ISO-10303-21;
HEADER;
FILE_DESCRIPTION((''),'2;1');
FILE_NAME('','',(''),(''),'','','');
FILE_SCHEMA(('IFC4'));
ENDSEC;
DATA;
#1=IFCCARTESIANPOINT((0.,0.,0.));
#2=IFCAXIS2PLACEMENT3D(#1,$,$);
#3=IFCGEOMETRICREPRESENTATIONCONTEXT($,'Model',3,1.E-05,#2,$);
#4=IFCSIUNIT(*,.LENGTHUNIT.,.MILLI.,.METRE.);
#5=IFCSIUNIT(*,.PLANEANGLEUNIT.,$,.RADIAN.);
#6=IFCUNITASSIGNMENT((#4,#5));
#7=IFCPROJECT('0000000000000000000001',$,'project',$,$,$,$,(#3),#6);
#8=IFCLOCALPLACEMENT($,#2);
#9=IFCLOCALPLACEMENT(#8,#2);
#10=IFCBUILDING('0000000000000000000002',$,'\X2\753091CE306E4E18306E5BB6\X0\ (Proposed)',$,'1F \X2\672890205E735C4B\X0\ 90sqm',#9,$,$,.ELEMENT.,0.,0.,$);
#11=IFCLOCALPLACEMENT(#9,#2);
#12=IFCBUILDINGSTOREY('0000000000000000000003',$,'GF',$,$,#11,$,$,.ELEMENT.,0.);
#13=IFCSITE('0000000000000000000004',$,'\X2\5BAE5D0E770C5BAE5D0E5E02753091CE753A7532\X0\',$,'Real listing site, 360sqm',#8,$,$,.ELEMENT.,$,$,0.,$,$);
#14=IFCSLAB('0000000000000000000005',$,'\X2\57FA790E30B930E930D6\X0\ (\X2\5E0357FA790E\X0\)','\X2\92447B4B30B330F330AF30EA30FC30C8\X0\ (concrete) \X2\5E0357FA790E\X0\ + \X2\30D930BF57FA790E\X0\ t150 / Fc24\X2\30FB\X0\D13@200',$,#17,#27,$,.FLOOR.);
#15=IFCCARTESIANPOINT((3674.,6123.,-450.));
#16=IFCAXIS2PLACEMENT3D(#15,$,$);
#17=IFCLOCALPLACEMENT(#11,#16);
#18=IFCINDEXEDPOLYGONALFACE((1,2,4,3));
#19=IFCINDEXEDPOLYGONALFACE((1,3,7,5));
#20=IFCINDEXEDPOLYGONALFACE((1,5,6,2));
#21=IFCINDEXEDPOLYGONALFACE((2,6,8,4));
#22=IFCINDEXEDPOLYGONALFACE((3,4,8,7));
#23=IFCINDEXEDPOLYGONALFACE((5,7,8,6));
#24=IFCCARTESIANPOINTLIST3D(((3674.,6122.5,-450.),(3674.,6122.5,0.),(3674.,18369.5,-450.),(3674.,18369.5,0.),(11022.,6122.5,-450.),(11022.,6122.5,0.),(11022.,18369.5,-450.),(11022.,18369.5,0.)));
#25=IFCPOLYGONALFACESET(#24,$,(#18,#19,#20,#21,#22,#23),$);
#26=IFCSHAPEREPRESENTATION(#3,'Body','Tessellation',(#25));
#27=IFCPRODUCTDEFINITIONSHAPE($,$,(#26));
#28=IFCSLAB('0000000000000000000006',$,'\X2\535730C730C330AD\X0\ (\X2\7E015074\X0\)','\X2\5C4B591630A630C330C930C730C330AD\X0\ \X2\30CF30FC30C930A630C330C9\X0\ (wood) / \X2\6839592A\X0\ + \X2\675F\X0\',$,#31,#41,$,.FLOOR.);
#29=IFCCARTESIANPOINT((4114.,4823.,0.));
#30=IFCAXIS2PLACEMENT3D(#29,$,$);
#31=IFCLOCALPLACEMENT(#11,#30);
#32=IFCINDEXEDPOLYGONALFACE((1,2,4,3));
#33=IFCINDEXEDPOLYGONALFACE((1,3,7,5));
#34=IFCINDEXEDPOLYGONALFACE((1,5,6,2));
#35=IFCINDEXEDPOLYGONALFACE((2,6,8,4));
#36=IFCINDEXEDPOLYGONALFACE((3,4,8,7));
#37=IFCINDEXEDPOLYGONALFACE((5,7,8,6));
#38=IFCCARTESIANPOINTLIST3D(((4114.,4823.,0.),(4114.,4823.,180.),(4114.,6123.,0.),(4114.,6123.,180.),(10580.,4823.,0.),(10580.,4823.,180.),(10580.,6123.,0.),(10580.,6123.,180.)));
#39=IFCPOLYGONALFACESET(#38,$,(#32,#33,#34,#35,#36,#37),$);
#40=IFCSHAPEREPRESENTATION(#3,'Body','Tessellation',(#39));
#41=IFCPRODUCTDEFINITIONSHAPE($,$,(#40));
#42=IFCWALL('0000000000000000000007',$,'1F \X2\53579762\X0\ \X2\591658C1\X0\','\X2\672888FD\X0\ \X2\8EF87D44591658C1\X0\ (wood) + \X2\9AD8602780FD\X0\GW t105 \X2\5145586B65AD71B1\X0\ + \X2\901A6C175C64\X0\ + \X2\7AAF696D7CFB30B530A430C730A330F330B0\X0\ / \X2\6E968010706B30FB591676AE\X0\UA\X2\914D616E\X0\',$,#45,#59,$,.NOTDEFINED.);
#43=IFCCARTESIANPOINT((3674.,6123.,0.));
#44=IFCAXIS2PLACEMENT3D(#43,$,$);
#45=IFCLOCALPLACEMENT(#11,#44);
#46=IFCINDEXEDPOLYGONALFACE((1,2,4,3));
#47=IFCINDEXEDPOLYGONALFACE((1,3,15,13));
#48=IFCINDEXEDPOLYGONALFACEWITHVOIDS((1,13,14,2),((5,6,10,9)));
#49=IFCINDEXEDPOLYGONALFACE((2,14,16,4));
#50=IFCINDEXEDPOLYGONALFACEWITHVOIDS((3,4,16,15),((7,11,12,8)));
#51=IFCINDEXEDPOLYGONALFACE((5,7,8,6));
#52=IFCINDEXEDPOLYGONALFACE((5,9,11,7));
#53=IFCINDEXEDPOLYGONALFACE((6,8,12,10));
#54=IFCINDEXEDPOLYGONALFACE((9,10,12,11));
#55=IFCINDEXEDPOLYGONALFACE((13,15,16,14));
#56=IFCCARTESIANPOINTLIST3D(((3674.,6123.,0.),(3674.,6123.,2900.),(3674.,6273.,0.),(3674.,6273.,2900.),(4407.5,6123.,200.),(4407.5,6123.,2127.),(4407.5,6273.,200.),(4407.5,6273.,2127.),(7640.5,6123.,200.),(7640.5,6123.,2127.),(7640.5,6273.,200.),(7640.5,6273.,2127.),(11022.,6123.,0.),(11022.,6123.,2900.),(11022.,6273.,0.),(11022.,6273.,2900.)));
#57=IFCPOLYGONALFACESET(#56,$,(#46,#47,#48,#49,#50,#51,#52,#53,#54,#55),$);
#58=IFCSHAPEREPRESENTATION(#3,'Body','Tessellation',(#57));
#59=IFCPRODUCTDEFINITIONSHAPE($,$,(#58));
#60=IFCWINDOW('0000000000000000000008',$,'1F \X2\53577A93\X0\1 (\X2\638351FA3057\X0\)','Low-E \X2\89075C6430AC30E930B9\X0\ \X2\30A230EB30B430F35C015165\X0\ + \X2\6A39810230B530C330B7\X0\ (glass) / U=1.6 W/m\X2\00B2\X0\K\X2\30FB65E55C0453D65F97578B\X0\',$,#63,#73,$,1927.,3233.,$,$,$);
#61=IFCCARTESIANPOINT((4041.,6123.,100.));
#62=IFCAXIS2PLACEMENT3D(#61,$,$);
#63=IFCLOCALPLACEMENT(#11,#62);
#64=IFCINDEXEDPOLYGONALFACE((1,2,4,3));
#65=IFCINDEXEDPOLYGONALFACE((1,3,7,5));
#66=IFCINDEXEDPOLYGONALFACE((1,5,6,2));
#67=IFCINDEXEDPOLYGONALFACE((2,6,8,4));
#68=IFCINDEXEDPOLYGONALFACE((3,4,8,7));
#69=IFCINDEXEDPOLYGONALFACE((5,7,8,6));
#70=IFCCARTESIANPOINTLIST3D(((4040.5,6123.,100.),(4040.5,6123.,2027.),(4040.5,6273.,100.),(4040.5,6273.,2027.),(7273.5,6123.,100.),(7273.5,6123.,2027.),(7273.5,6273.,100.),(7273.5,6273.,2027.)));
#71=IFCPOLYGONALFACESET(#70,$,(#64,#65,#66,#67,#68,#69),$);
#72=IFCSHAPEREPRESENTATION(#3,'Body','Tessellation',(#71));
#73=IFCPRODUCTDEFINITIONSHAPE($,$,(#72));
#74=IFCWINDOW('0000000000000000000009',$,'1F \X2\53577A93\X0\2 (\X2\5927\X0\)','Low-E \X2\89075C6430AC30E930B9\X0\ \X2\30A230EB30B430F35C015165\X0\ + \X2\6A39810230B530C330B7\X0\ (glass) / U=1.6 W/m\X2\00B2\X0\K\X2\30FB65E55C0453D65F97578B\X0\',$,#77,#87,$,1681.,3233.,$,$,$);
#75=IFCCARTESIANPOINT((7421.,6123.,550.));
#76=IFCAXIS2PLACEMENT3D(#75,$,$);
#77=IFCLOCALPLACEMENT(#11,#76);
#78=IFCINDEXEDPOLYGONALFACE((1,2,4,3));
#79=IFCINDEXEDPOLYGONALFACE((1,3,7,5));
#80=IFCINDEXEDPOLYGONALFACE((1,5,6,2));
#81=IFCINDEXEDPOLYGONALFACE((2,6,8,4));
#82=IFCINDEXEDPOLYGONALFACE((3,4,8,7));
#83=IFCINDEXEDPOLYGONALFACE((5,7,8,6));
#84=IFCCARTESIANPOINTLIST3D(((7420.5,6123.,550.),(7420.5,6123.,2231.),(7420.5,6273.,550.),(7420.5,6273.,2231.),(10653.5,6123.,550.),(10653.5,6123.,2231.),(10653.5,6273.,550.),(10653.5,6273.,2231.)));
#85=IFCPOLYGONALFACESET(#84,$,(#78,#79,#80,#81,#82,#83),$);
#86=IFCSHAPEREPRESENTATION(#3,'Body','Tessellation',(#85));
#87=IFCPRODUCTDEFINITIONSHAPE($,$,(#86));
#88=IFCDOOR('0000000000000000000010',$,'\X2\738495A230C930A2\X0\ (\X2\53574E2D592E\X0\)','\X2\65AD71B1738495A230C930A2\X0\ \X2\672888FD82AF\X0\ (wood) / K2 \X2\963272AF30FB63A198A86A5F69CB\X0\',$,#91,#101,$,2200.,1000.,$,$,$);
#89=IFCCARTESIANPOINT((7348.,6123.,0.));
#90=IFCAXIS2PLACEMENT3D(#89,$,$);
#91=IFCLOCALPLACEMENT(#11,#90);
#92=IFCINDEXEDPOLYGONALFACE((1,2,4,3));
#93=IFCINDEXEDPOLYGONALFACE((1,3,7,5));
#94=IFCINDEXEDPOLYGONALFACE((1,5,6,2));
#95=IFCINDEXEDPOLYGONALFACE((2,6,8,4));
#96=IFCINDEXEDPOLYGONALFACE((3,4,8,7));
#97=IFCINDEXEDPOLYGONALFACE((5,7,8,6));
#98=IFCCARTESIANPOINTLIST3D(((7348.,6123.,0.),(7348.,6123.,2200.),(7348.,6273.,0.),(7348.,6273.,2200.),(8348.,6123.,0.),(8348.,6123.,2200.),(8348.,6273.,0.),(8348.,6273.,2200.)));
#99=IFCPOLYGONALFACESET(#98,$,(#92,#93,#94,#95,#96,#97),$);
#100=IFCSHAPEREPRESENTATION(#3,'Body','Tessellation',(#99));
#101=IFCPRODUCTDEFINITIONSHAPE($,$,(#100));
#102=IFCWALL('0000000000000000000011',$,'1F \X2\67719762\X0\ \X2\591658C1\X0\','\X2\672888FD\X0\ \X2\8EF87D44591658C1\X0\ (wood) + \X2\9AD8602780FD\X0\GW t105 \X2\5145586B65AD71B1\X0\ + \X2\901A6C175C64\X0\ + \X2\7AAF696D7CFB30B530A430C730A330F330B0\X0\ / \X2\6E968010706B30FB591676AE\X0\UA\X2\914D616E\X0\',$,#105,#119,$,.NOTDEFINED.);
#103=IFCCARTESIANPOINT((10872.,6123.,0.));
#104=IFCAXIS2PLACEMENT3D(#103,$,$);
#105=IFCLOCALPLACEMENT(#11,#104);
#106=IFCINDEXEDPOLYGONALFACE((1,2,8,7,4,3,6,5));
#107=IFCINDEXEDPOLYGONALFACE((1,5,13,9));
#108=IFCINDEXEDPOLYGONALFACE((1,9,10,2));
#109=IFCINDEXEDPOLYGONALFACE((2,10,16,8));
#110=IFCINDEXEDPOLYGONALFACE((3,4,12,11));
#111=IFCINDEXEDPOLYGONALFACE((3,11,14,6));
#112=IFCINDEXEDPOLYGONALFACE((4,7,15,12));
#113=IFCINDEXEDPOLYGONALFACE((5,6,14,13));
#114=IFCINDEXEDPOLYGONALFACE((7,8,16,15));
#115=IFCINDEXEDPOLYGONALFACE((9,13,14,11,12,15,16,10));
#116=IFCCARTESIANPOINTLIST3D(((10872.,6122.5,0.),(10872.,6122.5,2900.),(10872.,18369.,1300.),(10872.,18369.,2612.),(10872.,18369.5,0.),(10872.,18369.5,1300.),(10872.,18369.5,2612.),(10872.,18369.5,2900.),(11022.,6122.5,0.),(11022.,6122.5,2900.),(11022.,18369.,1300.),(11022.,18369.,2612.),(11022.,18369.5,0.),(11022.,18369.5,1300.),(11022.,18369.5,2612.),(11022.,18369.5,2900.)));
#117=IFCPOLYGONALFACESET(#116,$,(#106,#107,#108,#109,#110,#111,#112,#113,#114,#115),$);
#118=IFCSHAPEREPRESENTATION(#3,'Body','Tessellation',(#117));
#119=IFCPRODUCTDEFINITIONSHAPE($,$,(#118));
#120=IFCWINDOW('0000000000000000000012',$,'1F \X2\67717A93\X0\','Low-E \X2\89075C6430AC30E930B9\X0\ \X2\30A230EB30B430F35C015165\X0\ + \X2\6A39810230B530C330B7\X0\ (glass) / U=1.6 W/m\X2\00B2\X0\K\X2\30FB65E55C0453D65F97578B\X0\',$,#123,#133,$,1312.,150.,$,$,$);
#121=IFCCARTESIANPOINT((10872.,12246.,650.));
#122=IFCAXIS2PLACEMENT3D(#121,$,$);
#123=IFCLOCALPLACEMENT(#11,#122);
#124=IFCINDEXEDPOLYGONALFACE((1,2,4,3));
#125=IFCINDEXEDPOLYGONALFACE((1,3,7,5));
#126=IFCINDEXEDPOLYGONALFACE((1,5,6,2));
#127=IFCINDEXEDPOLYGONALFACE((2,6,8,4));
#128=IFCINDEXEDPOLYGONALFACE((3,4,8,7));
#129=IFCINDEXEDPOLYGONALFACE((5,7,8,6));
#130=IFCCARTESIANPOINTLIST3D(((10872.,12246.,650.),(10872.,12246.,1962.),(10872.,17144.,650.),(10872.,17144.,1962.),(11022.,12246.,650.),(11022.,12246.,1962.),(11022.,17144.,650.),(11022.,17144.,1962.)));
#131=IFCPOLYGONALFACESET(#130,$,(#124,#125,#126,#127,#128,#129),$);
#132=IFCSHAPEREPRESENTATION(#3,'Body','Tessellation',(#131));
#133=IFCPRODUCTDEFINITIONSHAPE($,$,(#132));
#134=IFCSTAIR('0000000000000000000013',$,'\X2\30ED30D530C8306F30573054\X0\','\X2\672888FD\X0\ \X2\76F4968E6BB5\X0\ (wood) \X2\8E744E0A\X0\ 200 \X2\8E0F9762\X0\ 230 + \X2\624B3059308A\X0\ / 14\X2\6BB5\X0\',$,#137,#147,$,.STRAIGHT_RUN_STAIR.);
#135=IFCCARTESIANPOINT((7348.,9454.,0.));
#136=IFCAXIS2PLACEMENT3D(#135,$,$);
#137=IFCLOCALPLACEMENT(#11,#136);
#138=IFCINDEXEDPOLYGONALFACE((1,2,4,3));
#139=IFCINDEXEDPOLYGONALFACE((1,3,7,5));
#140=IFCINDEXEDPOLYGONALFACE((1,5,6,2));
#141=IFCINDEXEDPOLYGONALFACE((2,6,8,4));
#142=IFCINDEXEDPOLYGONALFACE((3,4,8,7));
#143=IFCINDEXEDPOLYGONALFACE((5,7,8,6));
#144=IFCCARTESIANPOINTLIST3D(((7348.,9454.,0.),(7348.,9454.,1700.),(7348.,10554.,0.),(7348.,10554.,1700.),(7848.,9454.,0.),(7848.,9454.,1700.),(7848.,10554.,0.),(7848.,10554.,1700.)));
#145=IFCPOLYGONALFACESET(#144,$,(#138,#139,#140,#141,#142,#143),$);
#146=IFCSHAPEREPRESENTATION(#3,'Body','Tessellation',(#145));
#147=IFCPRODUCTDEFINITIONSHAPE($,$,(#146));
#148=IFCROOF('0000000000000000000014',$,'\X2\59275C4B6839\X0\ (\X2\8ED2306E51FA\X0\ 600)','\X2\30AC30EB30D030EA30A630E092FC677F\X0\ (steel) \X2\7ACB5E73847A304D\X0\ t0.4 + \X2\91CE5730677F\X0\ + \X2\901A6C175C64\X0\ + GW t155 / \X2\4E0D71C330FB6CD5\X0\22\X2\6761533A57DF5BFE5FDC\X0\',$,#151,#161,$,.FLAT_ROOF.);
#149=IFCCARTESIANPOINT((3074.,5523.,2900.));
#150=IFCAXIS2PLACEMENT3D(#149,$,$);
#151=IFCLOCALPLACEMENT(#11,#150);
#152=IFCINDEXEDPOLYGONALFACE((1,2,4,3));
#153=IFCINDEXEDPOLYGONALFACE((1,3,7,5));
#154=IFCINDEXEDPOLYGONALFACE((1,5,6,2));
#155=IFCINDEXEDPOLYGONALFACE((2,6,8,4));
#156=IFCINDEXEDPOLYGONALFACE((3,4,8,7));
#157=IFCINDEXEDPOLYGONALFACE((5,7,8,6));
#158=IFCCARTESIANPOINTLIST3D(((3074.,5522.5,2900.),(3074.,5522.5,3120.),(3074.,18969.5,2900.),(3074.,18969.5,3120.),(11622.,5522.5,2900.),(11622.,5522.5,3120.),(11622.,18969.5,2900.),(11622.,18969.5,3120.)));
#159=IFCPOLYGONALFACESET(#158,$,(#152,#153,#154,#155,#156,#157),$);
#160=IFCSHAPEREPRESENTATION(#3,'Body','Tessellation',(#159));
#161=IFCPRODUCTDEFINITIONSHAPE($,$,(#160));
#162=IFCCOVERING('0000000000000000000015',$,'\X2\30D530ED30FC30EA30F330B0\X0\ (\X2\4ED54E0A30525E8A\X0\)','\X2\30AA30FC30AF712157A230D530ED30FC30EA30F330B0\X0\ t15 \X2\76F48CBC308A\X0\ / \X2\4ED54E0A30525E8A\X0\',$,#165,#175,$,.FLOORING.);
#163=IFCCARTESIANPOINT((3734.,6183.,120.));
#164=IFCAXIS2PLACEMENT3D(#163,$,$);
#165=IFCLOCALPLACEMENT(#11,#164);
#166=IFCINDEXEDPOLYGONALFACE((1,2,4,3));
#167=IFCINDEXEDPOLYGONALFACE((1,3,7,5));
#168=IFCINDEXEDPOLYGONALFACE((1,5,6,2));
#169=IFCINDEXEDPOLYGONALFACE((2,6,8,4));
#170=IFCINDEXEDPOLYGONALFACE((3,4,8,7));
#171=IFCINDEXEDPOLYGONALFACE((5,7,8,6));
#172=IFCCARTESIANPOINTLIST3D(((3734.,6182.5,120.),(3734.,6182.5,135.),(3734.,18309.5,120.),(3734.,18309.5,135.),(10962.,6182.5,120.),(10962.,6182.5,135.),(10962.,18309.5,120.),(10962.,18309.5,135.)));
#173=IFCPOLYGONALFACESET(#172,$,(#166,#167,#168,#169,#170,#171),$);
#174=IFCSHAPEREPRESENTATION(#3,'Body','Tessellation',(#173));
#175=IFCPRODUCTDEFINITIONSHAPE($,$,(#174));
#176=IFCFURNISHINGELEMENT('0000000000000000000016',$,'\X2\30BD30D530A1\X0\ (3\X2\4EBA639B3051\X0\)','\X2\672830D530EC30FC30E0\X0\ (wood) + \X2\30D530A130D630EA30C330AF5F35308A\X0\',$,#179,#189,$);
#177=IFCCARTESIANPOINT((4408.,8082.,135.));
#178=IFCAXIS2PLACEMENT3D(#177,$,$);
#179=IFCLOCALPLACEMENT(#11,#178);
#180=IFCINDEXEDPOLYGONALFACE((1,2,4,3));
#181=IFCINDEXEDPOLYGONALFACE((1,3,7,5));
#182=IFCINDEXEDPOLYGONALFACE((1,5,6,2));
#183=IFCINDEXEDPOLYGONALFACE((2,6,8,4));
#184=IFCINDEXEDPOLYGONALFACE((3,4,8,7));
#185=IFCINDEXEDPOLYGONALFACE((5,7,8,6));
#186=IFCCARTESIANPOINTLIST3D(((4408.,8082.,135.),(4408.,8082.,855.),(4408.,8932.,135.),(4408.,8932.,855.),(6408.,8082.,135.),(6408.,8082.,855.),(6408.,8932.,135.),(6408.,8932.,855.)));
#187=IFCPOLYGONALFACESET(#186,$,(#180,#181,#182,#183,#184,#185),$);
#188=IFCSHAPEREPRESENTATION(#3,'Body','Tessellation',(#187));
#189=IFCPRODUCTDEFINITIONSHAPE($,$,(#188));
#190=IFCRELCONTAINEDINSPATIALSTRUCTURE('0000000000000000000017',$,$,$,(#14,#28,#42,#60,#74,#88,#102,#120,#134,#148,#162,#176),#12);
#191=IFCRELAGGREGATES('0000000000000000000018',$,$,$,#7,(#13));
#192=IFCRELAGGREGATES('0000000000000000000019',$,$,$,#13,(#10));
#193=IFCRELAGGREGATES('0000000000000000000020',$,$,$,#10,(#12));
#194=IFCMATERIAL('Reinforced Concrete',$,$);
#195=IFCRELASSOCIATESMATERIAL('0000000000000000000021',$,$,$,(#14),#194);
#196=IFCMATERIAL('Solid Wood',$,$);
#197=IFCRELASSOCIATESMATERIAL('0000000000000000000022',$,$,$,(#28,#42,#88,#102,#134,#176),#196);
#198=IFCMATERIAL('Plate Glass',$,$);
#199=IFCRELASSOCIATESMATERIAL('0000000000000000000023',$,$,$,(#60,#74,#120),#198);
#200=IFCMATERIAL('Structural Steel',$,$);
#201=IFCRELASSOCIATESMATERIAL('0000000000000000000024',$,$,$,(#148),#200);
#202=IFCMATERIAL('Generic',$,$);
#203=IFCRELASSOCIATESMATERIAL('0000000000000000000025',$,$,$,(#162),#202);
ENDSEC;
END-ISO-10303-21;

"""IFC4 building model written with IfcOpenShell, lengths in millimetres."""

from ifc_helpers import new_model, si_unit, frame, frame_2d, origin, place, context, project, spatial, rectangle, extrude, material, element, fill, save


model = new_model("IFC4")

# Units and contexts
model_context = context("Model", 3, precision=1e-05, world=origin())
ifc_project = project(units=[si_unit("LENGTHUNIT", "METRE", prefix="MILLI"), si_unit("PLANEANGLEUNIT", "RADIAN")], contexts=[model_context])

# Site, building, storey
site_placement = place(None, origin())
site = spatial("IfcSite", under=ifc_project, at=site_placement, Name="宮崎県宮崎市田野町甲", ObjectType="Real listing site, 360sqm", CompositionType="ELEMENT", RefElevation=0.0)
building_placement = place(site_placement, origin())
building = spatial("IfcBuilding", under=site, at=building_placement, Name="田野の丘の家 (Proposed)", ObjectType="1F 木造平屋 90sqm", CompositionType="ELEMENT", ElevationOfRefHeight=0.0, ElevationOfTerrain=0.0)
storey_placement = place(building_placement, origin())
storey = spatial("IfcBuildingStorey", under=building, at=storey_placement, Name="GF", CompositionType="ELEMENT", Elevation=0.0)

# Slabs
ifc_material_1 = material(Name="Reinforced Concrete")
slab_1_placement = place(storey_placement, frame((3674.0, 6123.0, -450.0)))
element("IfcSlab", 1, at=slab_1_placement, inside=storey, material=ifc_material_1, Name="基礎スラブ (布基礎)", Description="鉄筋コンクリート (concrete) 布基礎 + ベタ基礎 t150 / Fc24・D13@200", PredefinedType="FLOOR", context=model_context, shape_type="SweptSolid", body=[
    extrude(rectangle(XDim=7348.0, YDim=12247.0, at=frame_2d((3674.0, 6123.0))), frame((3674.0, 6123.0, -450.0)), (0.0, 0.0, 1.0), 450.0),
])
ifc_material_2 = material(Name="Solid Wood")
slab_2_placement = place(storey_placement, frame((4114.0, 4823.0, 0.0)))
element("IfcSlab", 2, at=slab_2_placement, inside=storey, material=ifc_material_2, Name="南デッキ (縁側)", Description="屋外ウッドデッキ ハードウッド (wood) / 根太 + 束", PredefinedType="FLOOR", context=model_context, shape_type="SweptSolid", body=[
    extrude(rectangle(XDim=6466.0, YDim=1300.0, at=frame_2d((3233.0, 650.0))), frame((4114.0, 4823.0, 0.0)), (0.0, 0.0, 1.0), 180.0),
])

# Wall, openings, windows, door
wall_1_placement = place(storey_placement, frame((3674.0, 6123.0, 0.0)))
wall_1 = element("IfcWall", 3, at=wall_1_placement, inside=storey, material=ifc_material_2, Name="1F 南面 外壁", Description="木製 軸組外壁 (wood) + 高性能GW t105 充填断熱 + 通気層 + 窯業系サイディング / 準耐火・外皮UA配慮", PredefinedType="NOTDEFINED", context=model_context, shape_type="SweptSolid", body=[
    extrude(rectangle(XDim=7348.0, YDim=150.0, at=frame_2d((3674.0, 75.0))), frame((3674.0, 6123.0, 0.0)), (0.0, 0.0, 1.0), 2900.0),
])
opening_1_placement = place(storey_placement, frame((4041.0, 6123.0, 100.0)))
opening_1 = element("IfcOpeningElement", 4, at=opening_1_placement, cuts=wall_1, PredefinedType="NOTDEFINED", context=model_context, shape_type="SweptSolid", body=[
    extrude(rectangle(XDim=3233.0, YDim=150.0, at=frame_2d((1616.0, 75.0))), frame((4041.0, 6123.0, 100.0)), (0.0, 0.0, 1.0), 1927.0),
])
opening_2_placement = place(storey_placement, frame((7421.0, 6123.0, 550.0)))
opening_2 = element("IfcOpeningElement", 5, at=opening_2_placement, cuts=wall_1, PredefinedType="NOTDEFINED", context=model_context, shape_type="SweptSolid", body=[
    extrude(rectangle(XDim=3233.0, YDim=150.0, at=frame_2d((1616.0, 75.0))), frame((7421.0, 6123.0, 550.0)), (0.0, 0.0, 1.0), 1681.0),
])
opening_3_placement = place(storey_placement, frame((7348.0, 6123.0, 0.0)))
opening_3 = element("IfcOpeningElement", 6, at=opening_3_placement, cuts=wall_1, PredefinedType="NOTDEFINED", context=model_context, shape_type="SweptSolid", body=[
    extrude(rectangle(XDim=1000.0, YDim=150.0, at=frame_2d((500.0, 75.0))), frame((7348.0, 6123.0, 0.0)), (0.0, 0.0, 1.0), 2200.0),
])
ifc_material_3 = material(Name="Plate Glass")
window_1_placement = place(storey_placement, frame((4041.0, 6123.0, 100.0)))
window_1 = element("IfcWindow", 7, at=window_1_placement, inside=storey, material=ifc_material_3, Name="1F 南窓1 (掃出し)", Description="Low-E 複層ガラス アルゴン封入 + 樹脂サッシ (glass) / U=1.6 W/m²K・日射取得型", OverallHeight=1927.0, OverallWidth=3233.0, context=model_context, shape_type="SweptSolid", body=[
    extrude(rectangle(XDim=3233.0, YDim=150.0, at=frame_2d((1616.0, 75.0))), frame((4041.0, 6123.0, 100.0)), (0.0, 0.0, 1.0), 1927.0),
])
fill(opening_1, window_1)
window_2_placement = place(storey_placement, frame((7421.0, 6123.0, 550.0)))
window_2 = element("IfcWindow", 8, at=window_2_placement, inside=storey, material=ifc_material_3, Name="1F 南窓2 (大)", Description="Low-E 複層ガラス アルゴン封入 + 樹脂サッシ (glass) / U=1.6 W/m²K・日射取得型", OverallHeight=1681.0, OverallWidth=3233.0, context=model_context, shape_type="SweptSolid", body=[
    extrude(rectangle(XDim=3233.0, YDim=150.0, at=frame_2d((1616.0, 75.0))), frame((7421.0, 6123.0, 550.0)), (0.0, 0.0, 1.0), 1681.0),
])
fill(opening_2, window_2)
door_placement = place(storey_placement, frame((7348.0, 6123.0, 0.0)))
door = element("IfcDoor", 9, at=door_placement, inside=storey, material=ifc_material_2, Name="玄関ドア (南中央)", Description="断熱玄関ドア 木製芯 (wood) / K2 防犯・採風機構", OverallHeight=2200.0, OverallWidth=1000.0, context=model_context, shape_type="SweptSolid", body=[
    extrude(rectangle(XDim=1000.0, YDim=150.0, at=frame_2d((500.0, 75.0))), frame((7348.0, 6123.0, 0.0)), (0.0, 0.0, 1.0), 2200.0),
])
fill(opening_3, door)

# Wall, opening, window
wall_2_placement = place(storey_placement, frame((10872.0, 6123.0, 0.0)))
wall_2 = element("IfcWall", 10, at=wall_2_placement, inside=storey, material=ifc_material_2, Name="1F 東面 外壁", Description="木製 軸組外壁 (wood) + 高性能GW t105 充填断熱 + 通気層 + 窯業系サイディング / 準耐火・外皮UA配慮", PredefinedType="NOTDEFINED", context=model_context, shape_type="SweptSolid", body=[
    extrude(rectangle(XDim=150.0, YDim=12247.0, at=frame_2d((75.0, 6123.0))), frame((10872.0, 6123.0, 0.0)), (0.0, 0.0, 1.0), 2900.0),
])
opening_4_placement = place(storey_placement, frame((10872.0, 12246.0, 650.0)))
opening_4 = element("IfcOpeningElement", 11, at=opening_4_placement, cuts=wall_2, PredefinedType="NOTDEFINED", context=model_context, shape_type="SweptSolid", body=[
    extrude(rectangle(XDim=150.0, YDim=4898.0, at=frame_2d((75.0, 2449.0))), frame((10872.0, 12246.0, 650.0)), (0.0, 0.0, 1.0), 1312.0),
])
window_3_placement = place(storey_placement, frame((10872.0, 12246.0, 650.0)))
window_3 = element("IfcWindow", 12, at=window_3_placement, inside=storey, material=ifc_material_3, Name="1F 東窓", Description="Low-E 複層ガラス アルゴン封入 + 樹脂サッシ (glass) / U=1.6 W/m²K・日射取得型", OverallHeight=1312.0, OverallWidth=150.0, context=model_context, shape_type="SweptSolid", body=[
    extrude(rectangle(XDim=150.0, YDim=4898.0, at=frame_2d((75.0, 2449.0))), frame((10872.0, 12246.0, 650.0)), (0.0, 0.0, 1.0), 1312.0),
])
fill(opening_4, window_3)

# Stair
stair_placement = place(storey_placement, frame((7348.0, 9454.0, 0.0)))
element("IfcStair", 13, at=stair_placement, inside=storey, material=ifc_material_2, Name="ロフトはしご", Description="木製 直階段 (wood) 蹴上 200 踏面 230 + 手すり / 14段", PredefinedType="STRAIGHT_RUN_STAIR", context=model_context, shape_type="SweptSolid", body=[
    extrude(rectangle(XDim=500.0, YDim=1100.0, at=frame_2d((250.0, 550.0))), frame((7348.0, 9454.0, 0.0)), (0.0, 0.0, 1.0), 1700.0),
])

# Roof
ifc_material_4 = material(Name="Structural Steel")
roof_placement = place(storey_placement, frame((3074.0, 5523.0, 2900.0)))
element("IfcRoof", 14, at=roof_placement, inside=storey, material=ifc_material_4, Name="大屋根 (軒の出 600)", Description="ガルバリウム鋼板 (steel) 立平葺き t0.4 + 野地板 + 通気層 + GW t155 / 不燃・法22条区域対応", PredefinedType="FLAT_ROOF", context=model_context, shape_type="SweptSolid", body=[
    extrude(rectangle(XDim=8548.0, YDim=13447.0, at=frame_2d((4274.0, 6723.0))), frame((3074.0, 5523.0, 2900.0)), (0.0, 0.0, 1.0), 220.0),
])

# Covering
ifc_material_5 = material(Name="Generic")
covering_placement = place(storey_placement, frame((3734.0, 6183.0, 120.0)))
element("IfcCovering", 15, at=covering_placement, inside=storey, material=ifc_material_5, Name="フローリング (仕上げ床)", Description="オーク無垢フローリング t15 直貼り / 仕上げ床", PredefinedType="FLOORING", context=model_context, shape_type="SweptSolid", body=[
    extrude(rectangle(XDim=7228.0, YDim=12127.0, at=frame_2d((3614.0, 6063.0))), frame((3734.0, 6183.0, 120.0)), (0.0, 0.0, 1.0), 15.0),
])

# Furnishing element
furnishing_1_placement = place(storey_placement, frame((4408.0, 8082.0, 135.0)))
element("IfcFurnishingElement", 16, at=furnishing_1_placement, inside=storey, material=ifc_material_2, Name="ソファ (3人掛け)", Description="木フレーム (wood) + ファブリック張り", context=model_context, shape_type="SweptSolid", body=[
    extrude(rectangle(XDim=2000.0, YDim=850.0, at=frame_2d((1000.0, 425.0))), frame((4408.0, 8082.0, 135.0)), (0.0, 0.0, 1.0), 720.0),
])

save(model, "model.ifc")
